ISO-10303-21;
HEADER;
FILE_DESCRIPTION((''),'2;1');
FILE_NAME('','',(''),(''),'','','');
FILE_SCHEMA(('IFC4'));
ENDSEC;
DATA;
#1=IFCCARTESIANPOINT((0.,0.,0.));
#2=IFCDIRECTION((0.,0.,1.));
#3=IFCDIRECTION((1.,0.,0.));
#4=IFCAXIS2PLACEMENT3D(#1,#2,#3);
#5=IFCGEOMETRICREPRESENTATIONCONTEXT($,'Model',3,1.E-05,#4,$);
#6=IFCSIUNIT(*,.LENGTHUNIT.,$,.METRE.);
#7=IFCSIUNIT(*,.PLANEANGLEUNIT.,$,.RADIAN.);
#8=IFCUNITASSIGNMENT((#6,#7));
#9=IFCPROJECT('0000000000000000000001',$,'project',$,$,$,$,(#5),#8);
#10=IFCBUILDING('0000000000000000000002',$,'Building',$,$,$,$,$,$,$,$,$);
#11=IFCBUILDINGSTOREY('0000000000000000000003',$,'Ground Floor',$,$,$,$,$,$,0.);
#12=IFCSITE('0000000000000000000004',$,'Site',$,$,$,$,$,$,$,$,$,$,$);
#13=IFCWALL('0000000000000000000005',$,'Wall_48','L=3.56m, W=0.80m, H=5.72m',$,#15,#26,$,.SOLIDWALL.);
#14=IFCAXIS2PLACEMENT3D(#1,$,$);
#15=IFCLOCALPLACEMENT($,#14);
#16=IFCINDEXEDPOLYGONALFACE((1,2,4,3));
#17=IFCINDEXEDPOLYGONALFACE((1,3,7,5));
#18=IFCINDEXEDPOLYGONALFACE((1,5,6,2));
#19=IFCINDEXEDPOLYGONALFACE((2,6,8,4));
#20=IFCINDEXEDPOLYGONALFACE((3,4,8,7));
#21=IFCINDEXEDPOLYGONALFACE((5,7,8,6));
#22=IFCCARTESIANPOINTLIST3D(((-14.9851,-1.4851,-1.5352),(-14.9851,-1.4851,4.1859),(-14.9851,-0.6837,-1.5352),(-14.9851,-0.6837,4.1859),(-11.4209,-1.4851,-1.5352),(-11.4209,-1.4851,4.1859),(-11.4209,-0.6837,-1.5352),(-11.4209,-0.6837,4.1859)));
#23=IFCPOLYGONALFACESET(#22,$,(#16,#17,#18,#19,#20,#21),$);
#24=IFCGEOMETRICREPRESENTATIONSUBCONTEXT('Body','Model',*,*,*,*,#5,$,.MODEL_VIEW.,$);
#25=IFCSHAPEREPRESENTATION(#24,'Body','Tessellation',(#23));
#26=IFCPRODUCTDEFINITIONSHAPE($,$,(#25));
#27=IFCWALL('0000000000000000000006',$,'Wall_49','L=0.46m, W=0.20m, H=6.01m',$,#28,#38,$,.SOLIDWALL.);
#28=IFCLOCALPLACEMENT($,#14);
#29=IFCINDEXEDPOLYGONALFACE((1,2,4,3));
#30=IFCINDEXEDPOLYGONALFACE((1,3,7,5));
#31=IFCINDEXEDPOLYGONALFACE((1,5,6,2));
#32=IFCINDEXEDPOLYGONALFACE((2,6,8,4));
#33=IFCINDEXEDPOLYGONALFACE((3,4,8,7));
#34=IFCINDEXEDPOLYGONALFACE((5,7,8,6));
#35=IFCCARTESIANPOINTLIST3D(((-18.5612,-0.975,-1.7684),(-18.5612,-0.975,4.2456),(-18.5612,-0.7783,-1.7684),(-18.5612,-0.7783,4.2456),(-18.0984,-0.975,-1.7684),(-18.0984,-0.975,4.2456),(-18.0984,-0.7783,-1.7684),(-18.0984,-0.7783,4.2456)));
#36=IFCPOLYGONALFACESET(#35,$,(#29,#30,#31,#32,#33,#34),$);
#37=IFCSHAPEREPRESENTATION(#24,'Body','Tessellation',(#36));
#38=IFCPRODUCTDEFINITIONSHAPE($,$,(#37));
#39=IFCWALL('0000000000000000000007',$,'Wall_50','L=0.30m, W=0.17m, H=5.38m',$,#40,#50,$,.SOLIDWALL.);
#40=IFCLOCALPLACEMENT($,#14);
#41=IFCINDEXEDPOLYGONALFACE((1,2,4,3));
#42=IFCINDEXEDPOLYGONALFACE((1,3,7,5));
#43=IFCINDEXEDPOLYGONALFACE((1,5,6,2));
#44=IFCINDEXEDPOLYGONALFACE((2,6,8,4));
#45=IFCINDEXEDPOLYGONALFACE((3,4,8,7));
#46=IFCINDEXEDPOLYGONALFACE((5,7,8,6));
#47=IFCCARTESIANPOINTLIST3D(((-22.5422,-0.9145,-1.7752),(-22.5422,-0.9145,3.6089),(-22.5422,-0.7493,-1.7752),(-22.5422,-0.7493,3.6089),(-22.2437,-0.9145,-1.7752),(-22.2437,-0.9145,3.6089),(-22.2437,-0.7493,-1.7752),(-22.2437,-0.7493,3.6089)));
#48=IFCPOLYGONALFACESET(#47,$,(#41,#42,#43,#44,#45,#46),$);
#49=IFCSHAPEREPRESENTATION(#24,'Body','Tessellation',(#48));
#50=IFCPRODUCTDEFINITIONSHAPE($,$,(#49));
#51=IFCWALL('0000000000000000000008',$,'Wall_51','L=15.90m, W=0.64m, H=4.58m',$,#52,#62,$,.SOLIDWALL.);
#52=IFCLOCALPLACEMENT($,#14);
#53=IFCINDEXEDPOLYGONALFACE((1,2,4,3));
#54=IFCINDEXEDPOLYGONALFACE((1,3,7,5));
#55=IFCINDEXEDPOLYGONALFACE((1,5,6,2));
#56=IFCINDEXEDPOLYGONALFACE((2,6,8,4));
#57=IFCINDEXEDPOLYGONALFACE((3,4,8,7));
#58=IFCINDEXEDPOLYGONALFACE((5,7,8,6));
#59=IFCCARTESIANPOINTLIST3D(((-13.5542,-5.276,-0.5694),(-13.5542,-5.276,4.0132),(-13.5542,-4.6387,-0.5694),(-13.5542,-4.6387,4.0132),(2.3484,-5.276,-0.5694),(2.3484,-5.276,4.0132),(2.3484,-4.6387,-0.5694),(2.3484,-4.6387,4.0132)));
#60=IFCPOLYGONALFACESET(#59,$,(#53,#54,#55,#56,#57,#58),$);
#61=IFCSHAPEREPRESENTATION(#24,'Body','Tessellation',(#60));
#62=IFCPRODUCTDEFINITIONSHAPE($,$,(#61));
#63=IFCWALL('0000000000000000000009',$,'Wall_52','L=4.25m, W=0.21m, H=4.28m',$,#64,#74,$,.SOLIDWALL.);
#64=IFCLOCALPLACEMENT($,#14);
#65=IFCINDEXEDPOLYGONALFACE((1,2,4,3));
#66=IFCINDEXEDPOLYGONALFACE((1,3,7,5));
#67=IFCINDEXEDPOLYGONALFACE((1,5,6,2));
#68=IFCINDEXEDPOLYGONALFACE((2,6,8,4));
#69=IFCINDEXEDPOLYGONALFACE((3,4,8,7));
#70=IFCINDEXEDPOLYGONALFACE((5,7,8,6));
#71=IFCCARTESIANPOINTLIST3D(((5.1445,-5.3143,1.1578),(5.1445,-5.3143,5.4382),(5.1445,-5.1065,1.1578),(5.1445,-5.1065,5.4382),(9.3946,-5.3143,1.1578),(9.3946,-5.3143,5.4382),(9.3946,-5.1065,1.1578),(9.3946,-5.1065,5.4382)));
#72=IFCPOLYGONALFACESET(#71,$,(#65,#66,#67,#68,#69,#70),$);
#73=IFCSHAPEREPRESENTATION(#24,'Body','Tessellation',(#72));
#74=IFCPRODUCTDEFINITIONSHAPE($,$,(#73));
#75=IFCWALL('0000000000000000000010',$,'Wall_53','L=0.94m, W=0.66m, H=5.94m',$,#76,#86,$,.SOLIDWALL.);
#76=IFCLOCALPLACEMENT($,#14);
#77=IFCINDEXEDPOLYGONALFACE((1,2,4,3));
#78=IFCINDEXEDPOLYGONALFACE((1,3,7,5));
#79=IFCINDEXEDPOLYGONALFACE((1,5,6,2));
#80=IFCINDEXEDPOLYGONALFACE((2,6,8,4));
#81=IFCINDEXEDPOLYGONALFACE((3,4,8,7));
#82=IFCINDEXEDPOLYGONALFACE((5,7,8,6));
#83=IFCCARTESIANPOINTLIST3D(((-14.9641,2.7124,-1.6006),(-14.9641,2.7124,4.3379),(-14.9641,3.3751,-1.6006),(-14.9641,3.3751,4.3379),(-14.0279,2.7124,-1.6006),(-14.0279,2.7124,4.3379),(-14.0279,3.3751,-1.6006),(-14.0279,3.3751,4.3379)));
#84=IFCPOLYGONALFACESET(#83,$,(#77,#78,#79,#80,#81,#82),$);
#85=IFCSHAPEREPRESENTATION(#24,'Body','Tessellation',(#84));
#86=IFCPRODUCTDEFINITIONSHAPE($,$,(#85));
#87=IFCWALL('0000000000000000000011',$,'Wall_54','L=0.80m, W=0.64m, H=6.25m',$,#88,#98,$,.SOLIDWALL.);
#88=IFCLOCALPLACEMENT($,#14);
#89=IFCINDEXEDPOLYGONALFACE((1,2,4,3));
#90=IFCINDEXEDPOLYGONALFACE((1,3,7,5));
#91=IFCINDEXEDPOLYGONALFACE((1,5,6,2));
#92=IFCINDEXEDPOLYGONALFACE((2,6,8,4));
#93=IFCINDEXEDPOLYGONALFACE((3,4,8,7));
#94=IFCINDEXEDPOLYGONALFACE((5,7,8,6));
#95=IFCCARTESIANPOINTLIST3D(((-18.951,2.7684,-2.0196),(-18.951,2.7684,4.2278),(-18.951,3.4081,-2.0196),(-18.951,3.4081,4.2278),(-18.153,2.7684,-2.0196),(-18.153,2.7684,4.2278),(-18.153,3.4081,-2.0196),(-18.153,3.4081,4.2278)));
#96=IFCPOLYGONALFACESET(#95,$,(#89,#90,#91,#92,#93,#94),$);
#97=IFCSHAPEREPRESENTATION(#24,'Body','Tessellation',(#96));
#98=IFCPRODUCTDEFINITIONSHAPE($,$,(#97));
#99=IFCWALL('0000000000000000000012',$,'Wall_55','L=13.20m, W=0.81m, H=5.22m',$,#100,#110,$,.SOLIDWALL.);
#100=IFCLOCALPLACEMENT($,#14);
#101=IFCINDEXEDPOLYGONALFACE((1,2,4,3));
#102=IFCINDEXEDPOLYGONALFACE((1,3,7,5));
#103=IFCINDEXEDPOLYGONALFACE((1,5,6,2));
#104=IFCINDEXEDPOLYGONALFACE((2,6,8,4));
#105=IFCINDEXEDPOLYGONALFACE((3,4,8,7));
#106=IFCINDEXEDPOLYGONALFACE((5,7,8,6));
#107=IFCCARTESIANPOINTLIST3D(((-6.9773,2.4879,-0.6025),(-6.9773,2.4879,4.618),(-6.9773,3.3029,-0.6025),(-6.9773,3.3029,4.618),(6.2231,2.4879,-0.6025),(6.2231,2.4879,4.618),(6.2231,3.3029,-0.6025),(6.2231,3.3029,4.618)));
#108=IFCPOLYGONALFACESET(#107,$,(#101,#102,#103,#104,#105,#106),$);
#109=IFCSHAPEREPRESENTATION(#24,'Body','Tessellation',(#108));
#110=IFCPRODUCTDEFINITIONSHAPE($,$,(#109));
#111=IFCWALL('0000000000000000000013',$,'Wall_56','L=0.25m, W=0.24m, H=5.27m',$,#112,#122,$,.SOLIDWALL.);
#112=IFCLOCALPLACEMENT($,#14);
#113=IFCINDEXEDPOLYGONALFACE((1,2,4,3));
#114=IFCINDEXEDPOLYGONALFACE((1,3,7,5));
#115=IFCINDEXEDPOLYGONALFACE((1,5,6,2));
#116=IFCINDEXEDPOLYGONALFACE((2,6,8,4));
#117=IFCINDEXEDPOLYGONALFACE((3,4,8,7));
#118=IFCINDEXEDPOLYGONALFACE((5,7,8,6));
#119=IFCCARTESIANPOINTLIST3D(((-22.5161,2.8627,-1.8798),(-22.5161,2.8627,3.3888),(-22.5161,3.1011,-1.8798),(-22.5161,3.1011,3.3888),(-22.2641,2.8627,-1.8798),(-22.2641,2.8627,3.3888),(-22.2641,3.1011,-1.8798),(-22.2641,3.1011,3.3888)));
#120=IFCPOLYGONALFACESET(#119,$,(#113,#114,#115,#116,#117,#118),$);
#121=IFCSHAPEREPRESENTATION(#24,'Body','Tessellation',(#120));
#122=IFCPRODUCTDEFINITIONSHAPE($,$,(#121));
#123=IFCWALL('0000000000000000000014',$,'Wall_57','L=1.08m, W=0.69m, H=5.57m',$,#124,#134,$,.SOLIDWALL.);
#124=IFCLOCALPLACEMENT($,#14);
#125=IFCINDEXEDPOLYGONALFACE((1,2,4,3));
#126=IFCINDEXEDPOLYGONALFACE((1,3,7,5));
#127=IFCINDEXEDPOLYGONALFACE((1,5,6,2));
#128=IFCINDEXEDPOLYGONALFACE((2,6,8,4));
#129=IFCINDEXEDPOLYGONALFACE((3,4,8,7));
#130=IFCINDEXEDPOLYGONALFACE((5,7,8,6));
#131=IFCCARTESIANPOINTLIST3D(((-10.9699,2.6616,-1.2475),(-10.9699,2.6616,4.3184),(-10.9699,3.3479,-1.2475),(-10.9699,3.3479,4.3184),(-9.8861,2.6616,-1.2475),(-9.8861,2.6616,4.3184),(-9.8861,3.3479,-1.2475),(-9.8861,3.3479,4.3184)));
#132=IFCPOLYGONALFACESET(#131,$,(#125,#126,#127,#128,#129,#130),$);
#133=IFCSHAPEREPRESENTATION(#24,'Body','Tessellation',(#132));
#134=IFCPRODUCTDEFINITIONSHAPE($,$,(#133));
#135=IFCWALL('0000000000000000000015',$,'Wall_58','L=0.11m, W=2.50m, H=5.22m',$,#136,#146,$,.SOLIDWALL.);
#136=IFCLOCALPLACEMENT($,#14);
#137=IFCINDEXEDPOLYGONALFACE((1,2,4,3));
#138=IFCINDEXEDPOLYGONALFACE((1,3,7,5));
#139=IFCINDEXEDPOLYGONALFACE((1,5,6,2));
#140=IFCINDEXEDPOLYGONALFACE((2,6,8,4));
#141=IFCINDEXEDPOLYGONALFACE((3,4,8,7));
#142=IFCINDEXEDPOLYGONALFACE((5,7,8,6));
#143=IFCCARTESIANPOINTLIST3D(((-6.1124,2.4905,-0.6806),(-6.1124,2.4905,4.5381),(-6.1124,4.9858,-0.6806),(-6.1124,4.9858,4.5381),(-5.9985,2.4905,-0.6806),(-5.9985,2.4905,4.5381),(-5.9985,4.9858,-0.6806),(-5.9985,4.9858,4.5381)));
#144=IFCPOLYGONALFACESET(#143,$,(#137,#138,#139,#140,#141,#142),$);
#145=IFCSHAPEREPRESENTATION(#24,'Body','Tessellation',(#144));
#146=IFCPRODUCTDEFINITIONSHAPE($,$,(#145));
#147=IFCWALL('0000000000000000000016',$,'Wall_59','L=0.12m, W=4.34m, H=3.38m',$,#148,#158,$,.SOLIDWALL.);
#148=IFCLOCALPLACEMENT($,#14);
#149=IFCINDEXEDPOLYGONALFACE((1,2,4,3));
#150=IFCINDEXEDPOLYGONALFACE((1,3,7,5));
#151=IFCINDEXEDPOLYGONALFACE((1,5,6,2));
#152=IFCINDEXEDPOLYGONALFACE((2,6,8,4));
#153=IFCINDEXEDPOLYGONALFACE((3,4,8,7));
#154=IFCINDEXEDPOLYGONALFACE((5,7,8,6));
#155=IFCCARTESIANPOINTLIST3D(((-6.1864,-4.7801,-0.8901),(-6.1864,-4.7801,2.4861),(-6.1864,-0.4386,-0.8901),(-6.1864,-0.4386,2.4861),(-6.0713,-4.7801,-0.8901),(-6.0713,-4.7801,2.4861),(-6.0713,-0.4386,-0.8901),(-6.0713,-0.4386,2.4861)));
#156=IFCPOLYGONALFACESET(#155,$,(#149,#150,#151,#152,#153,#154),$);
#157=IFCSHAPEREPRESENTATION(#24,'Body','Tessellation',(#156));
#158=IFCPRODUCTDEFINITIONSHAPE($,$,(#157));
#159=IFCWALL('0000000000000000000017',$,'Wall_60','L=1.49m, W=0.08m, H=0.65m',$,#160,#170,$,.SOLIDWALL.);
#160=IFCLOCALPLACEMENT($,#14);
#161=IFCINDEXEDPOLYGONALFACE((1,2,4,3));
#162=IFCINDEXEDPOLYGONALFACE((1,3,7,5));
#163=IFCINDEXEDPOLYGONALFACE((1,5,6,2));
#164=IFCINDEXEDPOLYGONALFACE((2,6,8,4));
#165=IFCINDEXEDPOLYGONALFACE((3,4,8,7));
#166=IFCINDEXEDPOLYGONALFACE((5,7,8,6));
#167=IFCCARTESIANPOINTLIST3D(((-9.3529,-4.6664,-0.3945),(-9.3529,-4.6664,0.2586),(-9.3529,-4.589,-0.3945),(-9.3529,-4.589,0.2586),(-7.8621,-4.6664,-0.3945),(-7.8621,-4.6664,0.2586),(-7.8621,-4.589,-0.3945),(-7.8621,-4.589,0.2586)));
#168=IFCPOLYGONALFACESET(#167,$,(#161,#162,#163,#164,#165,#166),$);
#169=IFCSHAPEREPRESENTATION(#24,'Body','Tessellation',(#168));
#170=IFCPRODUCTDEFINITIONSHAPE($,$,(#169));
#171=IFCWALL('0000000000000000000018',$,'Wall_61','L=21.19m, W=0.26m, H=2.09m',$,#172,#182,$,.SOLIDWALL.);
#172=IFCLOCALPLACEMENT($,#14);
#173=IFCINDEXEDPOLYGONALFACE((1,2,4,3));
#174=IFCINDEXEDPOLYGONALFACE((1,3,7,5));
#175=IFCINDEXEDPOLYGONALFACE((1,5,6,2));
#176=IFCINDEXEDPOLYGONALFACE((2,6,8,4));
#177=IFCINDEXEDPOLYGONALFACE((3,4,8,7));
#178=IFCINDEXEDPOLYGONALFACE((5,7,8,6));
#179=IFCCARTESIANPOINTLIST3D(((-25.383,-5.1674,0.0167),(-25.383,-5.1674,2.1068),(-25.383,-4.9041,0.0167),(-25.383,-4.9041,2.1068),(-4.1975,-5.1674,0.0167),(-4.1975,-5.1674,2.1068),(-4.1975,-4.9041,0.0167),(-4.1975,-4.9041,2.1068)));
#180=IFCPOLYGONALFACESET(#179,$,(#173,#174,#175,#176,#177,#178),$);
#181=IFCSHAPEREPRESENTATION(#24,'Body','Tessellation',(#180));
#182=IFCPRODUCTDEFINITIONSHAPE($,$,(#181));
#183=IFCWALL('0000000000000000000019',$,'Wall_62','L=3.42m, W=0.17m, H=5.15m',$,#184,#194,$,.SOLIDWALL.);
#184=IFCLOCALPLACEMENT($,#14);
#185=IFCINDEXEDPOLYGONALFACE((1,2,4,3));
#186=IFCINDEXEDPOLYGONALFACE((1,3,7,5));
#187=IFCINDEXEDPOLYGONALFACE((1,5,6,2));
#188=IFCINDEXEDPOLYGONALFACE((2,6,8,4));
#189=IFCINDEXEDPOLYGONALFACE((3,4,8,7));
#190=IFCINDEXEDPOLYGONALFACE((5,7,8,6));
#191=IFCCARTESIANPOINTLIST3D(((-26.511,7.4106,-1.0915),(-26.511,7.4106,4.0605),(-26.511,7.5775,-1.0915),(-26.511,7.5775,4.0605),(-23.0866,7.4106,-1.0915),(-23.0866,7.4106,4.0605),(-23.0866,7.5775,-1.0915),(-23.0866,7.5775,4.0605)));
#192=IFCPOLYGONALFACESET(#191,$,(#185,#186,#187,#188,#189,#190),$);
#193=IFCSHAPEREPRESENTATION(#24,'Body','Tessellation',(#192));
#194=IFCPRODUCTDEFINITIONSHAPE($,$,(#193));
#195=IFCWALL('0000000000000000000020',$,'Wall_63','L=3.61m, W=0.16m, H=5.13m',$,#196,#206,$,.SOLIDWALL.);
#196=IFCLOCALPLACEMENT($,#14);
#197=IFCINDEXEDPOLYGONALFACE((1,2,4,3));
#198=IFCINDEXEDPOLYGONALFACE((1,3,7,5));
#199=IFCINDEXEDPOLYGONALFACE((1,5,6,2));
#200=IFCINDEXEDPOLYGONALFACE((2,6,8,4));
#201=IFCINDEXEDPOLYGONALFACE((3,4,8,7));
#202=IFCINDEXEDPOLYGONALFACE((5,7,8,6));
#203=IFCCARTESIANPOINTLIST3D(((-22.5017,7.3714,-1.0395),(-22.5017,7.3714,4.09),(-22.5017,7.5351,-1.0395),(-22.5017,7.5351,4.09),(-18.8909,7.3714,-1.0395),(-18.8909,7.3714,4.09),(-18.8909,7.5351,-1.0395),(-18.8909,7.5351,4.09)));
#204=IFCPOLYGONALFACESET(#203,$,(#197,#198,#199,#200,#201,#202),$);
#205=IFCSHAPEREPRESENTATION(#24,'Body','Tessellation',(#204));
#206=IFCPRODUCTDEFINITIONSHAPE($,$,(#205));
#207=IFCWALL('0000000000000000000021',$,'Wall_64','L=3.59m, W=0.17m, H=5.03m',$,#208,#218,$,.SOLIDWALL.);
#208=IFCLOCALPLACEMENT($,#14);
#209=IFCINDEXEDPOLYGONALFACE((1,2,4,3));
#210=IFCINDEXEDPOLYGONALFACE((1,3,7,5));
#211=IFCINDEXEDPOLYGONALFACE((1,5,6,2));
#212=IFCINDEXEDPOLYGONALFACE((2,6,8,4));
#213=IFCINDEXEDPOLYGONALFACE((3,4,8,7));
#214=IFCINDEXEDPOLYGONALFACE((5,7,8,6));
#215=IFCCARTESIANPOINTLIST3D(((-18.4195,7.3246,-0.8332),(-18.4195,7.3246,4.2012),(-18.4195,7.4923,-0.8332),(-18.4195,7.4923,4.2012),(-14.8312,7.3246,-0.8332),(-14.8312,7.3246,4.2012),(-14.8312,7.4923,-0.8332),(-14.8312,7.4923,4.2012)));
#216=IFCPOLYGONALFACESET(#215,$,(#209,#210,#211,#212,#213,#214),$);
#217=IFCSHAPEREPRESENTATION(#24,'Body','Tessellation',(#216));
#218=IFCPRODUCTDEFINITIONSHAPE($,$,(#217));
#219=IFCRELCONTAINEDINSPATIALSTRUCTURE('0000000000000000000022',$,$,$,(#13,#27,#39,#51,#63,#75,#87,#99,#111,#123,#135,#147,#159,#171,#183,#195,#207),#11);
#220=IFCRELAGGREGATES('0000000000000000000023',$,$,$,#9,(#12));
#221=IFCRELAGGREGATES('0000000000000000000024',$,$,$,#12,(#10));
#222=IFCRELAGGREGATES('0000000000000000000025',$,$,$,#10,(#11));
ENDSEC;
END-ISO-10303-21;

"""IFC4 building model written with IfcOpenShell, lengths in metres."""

from ifc_helpers import new_model, si_unit, frame, origin_with_axes, origin_2d, context, subcontext, project, spatial, rectangle, extrude, element, save


model = new_model("IFC4")

# Units and contexts
model_context = context("Model", 3, precision=1e-05, world=origin_with_axes())
body_context = subcontext(model_context, "Body", "Model", "MODEL_VIEW")
ifc_project = project(units=[si_unit("LENGTHUNIT", "METRE"), si_unit("PLANEANGLEUNIT", "RADIAN")], contexts=[model_context])

# Site, building, storey
site = spatial("IfcSite", under=ifc_project, Name="Site")
building = spatial("IfcBuilding", under=site, Name="Building")
storey = spatial("IfcBuildingStorey", under=building, Name="Ground Floor", Elevation=0.0)

# Walls
element("IfcWall", 1, inside=storey, Name="Wall_48", Description="L=3.56m, W=0.80m, H=5.72m", PredefinedType="SOLIDWALL", context=body_context, shape_type="SweptSolid", body=[
    extrude(rectangle(XDim=3.5642, YDim=0.8014, at=origin_2d()), frame((-13.203, -1.0844, -1.5352), z_axis=(0.0, 0.0, 1.0), x_axis=(1.0, 0.0, 0.0)), (0.0, 0.0, 1.0), 5.7211),
])
element("IfcWall", 2, inside=storey, Name="Wall_49", Description="L=0.46m, W=0.20m, H=6.01m", PredefinedType="SOLIDWALL", context=body_context, shape_type="SweptSolid", body=[
    extrude(rectangle(XDim=0.4628, YDim=0.1967, at=origin_2d()), frame((-18.3298, -0.8766, -1.7684), z_axis=(0.0, 0.0, 1.0), x_axis=(1.0, 0.0, 0.0)), (0.0, 0.0, 1.0), 6.014),
])
element("IfcWall", 3, inside=storey, Name="Wall_50", Description="L=0.30m, W=0.17m, H=5.38m", PredefinedType="SOLIDWALL", context=body_context, shape_type="SweptSolid", body=[
    extrude(rectangle(XDim=0.2985, YDim=0.1652, at=origin_2d()), frame((-22.3929, -0.8319, -1.7752), z_axis=(0.0, 0.0, 1.0), x_axis=(1.0, 0.0, 0.0)), (0.0, 0.0, 1.0), 5.3841),
])
element("IfcWall", 4, inside=storey, Name="Wall_51", Description="L=15.90m, W=0.64m, H=4.58m", PredefinedType="SOLIDWALL", context=body_context, shape_type="SweptSolid", body=[
    extrude(rectangle(XDim=15.9026, YDim=0.6373, at=origin_2d()), frame((-5.6029, -4.9573, -0.5694), z_axis=(0.0, 0.0, 1.0), x_axis=(1.0, 0.0, 0.0)), (0.0, 0.0, 1.0), 4.5827),
])
element("IfcWall", 5, inside=storey, Name="Wall_52", Description="L=4.25m, W=0.21m, H=4.28m", PredefinedType="SOLIDWALL", context=body_context, shape_type="SweptSolid", body=[
    extrude(rectangle(XDim=4.2501, YDim=0.2079, at=origin_2d()), frame((7.2695, -5.2104, 1.1578), z_axis=(0.0, 0.0, 1.0), x_axis=(1.0, 0.0, 0.0)), (0.0, 0.0, 1.0), 4.2804),
])
element("IfcWall", 6, inside=storey, Name="Wall_53", Description="L=0.94m, W=0.66m, H=5.94m", PredefinedType="SOLIDWALL", context=body_context, shape_type="SweptSolid", body=[
    extrude(rectangle(XDim=0.9362, YDim=0.6626, at=origin_2d()), frame((-14.496, 3.0438, -1.6006), z_axis=(0.0, 0.0, 1.0), x_axis=(1.0, 0.0, 0.0)), (0.0, 0.0, 1.0), 5.9385),
])
element("IfcWall", 7, inside=storey, Name="Wall_54", Description="L=0.80m, W=0.64m, H=6.25m", PredefinedType="SOLIDWALL", context=body_context, shape_type="SweptSolid", body=[
    extrude(rectangle(XDim=0.7979, YDim=0.6396, at=origin_2d()), frame((-18.552, 3.0883, -2.0196), z_axis=(0.0, 0.0, 1.0), x_axis=(1.0, 0.0, 0.0)), (0.0, 0.0, 1.0), 6.2474),
])
element("IfcWall", 8, inside=storey, Name="Wall_55", Description="L=13.20m, W=0.81m, H=5.22m", PredefinedType="SOLIDWALL", context=body_context, shape_type="SweptSolid", body=[
    extrude(rectangle(XDim=13.2003, YDim=0.815, at=origin_2d()), frame((-0.3771, 2.8954, -0.6025), z_axis=(0.0, 0.0, 1.0), x_axis=(1.0, 0.0, 0.0)), (0.0, 0.0, 1.0), 5.2206),
])
element("IfcWall", 9, inside=storey, Name="Wall_56", Description="L=0.25m, W=0.24m, H=5.27m", PredefinedType="SOLIDWALL", context=body_context, shape_type="SweptSolid", body=[
    extrude(rectangle(XDim=0.252, YDim=0.2384, at=origin_2d()), frame((-22.3901, 2.9819, -1.8798), z_axis=(0.0, 0.0, 1.0), x_axis=(1.0, 0.0, 0.0)), (0.0, 0.0, 1.0), 5.2687),
])
element("IfcWall", 10, inside=storey, Name="Wall_57", Description="L=1.08m, W=0.69m, H=5.57m", PredefinedType="SOLIDWALL", context=body_context, shape_type="SweptSolid", body=[
    extrude(rectangle(XDim=1.0838, YDim=0.6863, at=origin_2d()), frame((-10.428, 3.0048, -1.2475), z_axis=(0.0, 0.0, 1.0), x_axis=(1.0, 0.0, 0.0)), (0.0, 0.0, 1.0), 5.5659),
])
element("IfcWall", 11, inside=storey, Name="Wall_58", Description="L=0.11m, W=2.50m, H=5.22m", PredefinedType="SOLIDWALL", context=body_context, shape_type="SweptSolid", body=[
    extrude(rectangle(XDim=0.114, YDim=2.4953, at=origin_2d()), frame((-6.0555, 3.7382, -0.6806), z_axis=(0.0, 0.0, 1.0), x_axis=(1.0, 0.0, 0.0)), (0.0, 0.0, 1.0), 5.2186),
])
element("IfcWall", 12, inside=storey, Name="Wall_59", Description="L=0.12m, W=4.34m, H=3.38m", PredefinedType="SOLIDWALL", context=body_context, shape_type="SweptSolid", body=[
    extrude(rectangle(XDim=0.1151, YDim=4.3415, at=origin_2d()), frame((-6.1289, -2.6094, -0.8901), z_axis=(0.0, 0.0, 1.0), x_axis=(1.0, 0.0, 0.0)), (0.0, 0.0, 1.0), 3.3762),
])
element("IfcWall", 13, inside=storey, Name="Wall_60", Description="L=1.49m, W=0.08m, H=0.65m", PredefinedType="SOLIDWALL", context=body_context, shape_type="SweptSolid", body=[
    extrude(rectangle(XDim=1.4908, YDim=0.0774, at=origin_2d()), frame((-8.6075, -4.6277, -0.3945), z_axis=(0.0, 0.0, 1.0), x_axis=(1.0, 0.0, 0.0)), (0.0, 0.0, 1.0), 0.6531),
])
element("IfcWall", 14, inside=storey, Name="Wall_61", Description="L=21.19m, W=0.26m, H=2.09m", PredefinedType="SOLIDWALL", context=body_context, shape_type="SweptSolid", body=[
    extrude(rectangle(XDim=21.1854, YDim=0.2632, at=origin_2d()), frame((-14.7902, -5.0357, 0.0167), z_axis=(0.0, 0.0, 1.0), x_axis=(1.0, 0.0, 0.0)), (0.0, 0.0, 1.0), 2.0901),
])
element("IfcWall", 15, inside=storey, Name="Wall_62", Description="L=3.42m, W=0.17m, H=5.15m", PredefinedType="SOLIDWALL", context=body_context, shape_type="SweptSolid", body=[
    extrude(rectangle(XDim=3.4244, YDim=0.1669, at=origin_2d()), frame((-24.7988, 7.494, -1.0915), z_axis=(0.0, 0.0, 1.0), x_axis=(1.0, 0.0, 0.0)), (0.0, 0.0, 1.0), 5.152),
])
element("IfcWall", 16, inside=storey, Name="Wall_63", Description="L=3.61m, W=0.16m, H=5.13m", PredefinedType="SOLIDWALL", context=body_context, shape_type="SweptSolid", body=[
    extrude(rectangle(XDim=3.6108, YDim=0.1637, at=origin_2d()), frame((-20.6963, 7.4533, -1.0395), z_axis=(0.0, 0.0, 1.0), x_axis=(1.0, 0.0, 0.0)), (0.0, 0.0, 1.0), 5.1295),
])
element("IfcWall", 17, inside=storey, Name="Wall_64", Description="L=3.59m, W=0.17m, H=5.03m", PredefinedType="SOLIDWALL", context=body_context, shape_type="SweptSolid", body=[
    extrude(rectangle(XDim=3.5883, YDim=0.1677, at=origin_2d()), frame((-16.6253, 7.4085, -0.8332), z_axis=(0.0, 0.0, 1.0), x_axis=(1.0, 0.0, 0.0)), (0.0, 0.0, 1.0), 5.0343),
])

save(model, "model.ifc")
